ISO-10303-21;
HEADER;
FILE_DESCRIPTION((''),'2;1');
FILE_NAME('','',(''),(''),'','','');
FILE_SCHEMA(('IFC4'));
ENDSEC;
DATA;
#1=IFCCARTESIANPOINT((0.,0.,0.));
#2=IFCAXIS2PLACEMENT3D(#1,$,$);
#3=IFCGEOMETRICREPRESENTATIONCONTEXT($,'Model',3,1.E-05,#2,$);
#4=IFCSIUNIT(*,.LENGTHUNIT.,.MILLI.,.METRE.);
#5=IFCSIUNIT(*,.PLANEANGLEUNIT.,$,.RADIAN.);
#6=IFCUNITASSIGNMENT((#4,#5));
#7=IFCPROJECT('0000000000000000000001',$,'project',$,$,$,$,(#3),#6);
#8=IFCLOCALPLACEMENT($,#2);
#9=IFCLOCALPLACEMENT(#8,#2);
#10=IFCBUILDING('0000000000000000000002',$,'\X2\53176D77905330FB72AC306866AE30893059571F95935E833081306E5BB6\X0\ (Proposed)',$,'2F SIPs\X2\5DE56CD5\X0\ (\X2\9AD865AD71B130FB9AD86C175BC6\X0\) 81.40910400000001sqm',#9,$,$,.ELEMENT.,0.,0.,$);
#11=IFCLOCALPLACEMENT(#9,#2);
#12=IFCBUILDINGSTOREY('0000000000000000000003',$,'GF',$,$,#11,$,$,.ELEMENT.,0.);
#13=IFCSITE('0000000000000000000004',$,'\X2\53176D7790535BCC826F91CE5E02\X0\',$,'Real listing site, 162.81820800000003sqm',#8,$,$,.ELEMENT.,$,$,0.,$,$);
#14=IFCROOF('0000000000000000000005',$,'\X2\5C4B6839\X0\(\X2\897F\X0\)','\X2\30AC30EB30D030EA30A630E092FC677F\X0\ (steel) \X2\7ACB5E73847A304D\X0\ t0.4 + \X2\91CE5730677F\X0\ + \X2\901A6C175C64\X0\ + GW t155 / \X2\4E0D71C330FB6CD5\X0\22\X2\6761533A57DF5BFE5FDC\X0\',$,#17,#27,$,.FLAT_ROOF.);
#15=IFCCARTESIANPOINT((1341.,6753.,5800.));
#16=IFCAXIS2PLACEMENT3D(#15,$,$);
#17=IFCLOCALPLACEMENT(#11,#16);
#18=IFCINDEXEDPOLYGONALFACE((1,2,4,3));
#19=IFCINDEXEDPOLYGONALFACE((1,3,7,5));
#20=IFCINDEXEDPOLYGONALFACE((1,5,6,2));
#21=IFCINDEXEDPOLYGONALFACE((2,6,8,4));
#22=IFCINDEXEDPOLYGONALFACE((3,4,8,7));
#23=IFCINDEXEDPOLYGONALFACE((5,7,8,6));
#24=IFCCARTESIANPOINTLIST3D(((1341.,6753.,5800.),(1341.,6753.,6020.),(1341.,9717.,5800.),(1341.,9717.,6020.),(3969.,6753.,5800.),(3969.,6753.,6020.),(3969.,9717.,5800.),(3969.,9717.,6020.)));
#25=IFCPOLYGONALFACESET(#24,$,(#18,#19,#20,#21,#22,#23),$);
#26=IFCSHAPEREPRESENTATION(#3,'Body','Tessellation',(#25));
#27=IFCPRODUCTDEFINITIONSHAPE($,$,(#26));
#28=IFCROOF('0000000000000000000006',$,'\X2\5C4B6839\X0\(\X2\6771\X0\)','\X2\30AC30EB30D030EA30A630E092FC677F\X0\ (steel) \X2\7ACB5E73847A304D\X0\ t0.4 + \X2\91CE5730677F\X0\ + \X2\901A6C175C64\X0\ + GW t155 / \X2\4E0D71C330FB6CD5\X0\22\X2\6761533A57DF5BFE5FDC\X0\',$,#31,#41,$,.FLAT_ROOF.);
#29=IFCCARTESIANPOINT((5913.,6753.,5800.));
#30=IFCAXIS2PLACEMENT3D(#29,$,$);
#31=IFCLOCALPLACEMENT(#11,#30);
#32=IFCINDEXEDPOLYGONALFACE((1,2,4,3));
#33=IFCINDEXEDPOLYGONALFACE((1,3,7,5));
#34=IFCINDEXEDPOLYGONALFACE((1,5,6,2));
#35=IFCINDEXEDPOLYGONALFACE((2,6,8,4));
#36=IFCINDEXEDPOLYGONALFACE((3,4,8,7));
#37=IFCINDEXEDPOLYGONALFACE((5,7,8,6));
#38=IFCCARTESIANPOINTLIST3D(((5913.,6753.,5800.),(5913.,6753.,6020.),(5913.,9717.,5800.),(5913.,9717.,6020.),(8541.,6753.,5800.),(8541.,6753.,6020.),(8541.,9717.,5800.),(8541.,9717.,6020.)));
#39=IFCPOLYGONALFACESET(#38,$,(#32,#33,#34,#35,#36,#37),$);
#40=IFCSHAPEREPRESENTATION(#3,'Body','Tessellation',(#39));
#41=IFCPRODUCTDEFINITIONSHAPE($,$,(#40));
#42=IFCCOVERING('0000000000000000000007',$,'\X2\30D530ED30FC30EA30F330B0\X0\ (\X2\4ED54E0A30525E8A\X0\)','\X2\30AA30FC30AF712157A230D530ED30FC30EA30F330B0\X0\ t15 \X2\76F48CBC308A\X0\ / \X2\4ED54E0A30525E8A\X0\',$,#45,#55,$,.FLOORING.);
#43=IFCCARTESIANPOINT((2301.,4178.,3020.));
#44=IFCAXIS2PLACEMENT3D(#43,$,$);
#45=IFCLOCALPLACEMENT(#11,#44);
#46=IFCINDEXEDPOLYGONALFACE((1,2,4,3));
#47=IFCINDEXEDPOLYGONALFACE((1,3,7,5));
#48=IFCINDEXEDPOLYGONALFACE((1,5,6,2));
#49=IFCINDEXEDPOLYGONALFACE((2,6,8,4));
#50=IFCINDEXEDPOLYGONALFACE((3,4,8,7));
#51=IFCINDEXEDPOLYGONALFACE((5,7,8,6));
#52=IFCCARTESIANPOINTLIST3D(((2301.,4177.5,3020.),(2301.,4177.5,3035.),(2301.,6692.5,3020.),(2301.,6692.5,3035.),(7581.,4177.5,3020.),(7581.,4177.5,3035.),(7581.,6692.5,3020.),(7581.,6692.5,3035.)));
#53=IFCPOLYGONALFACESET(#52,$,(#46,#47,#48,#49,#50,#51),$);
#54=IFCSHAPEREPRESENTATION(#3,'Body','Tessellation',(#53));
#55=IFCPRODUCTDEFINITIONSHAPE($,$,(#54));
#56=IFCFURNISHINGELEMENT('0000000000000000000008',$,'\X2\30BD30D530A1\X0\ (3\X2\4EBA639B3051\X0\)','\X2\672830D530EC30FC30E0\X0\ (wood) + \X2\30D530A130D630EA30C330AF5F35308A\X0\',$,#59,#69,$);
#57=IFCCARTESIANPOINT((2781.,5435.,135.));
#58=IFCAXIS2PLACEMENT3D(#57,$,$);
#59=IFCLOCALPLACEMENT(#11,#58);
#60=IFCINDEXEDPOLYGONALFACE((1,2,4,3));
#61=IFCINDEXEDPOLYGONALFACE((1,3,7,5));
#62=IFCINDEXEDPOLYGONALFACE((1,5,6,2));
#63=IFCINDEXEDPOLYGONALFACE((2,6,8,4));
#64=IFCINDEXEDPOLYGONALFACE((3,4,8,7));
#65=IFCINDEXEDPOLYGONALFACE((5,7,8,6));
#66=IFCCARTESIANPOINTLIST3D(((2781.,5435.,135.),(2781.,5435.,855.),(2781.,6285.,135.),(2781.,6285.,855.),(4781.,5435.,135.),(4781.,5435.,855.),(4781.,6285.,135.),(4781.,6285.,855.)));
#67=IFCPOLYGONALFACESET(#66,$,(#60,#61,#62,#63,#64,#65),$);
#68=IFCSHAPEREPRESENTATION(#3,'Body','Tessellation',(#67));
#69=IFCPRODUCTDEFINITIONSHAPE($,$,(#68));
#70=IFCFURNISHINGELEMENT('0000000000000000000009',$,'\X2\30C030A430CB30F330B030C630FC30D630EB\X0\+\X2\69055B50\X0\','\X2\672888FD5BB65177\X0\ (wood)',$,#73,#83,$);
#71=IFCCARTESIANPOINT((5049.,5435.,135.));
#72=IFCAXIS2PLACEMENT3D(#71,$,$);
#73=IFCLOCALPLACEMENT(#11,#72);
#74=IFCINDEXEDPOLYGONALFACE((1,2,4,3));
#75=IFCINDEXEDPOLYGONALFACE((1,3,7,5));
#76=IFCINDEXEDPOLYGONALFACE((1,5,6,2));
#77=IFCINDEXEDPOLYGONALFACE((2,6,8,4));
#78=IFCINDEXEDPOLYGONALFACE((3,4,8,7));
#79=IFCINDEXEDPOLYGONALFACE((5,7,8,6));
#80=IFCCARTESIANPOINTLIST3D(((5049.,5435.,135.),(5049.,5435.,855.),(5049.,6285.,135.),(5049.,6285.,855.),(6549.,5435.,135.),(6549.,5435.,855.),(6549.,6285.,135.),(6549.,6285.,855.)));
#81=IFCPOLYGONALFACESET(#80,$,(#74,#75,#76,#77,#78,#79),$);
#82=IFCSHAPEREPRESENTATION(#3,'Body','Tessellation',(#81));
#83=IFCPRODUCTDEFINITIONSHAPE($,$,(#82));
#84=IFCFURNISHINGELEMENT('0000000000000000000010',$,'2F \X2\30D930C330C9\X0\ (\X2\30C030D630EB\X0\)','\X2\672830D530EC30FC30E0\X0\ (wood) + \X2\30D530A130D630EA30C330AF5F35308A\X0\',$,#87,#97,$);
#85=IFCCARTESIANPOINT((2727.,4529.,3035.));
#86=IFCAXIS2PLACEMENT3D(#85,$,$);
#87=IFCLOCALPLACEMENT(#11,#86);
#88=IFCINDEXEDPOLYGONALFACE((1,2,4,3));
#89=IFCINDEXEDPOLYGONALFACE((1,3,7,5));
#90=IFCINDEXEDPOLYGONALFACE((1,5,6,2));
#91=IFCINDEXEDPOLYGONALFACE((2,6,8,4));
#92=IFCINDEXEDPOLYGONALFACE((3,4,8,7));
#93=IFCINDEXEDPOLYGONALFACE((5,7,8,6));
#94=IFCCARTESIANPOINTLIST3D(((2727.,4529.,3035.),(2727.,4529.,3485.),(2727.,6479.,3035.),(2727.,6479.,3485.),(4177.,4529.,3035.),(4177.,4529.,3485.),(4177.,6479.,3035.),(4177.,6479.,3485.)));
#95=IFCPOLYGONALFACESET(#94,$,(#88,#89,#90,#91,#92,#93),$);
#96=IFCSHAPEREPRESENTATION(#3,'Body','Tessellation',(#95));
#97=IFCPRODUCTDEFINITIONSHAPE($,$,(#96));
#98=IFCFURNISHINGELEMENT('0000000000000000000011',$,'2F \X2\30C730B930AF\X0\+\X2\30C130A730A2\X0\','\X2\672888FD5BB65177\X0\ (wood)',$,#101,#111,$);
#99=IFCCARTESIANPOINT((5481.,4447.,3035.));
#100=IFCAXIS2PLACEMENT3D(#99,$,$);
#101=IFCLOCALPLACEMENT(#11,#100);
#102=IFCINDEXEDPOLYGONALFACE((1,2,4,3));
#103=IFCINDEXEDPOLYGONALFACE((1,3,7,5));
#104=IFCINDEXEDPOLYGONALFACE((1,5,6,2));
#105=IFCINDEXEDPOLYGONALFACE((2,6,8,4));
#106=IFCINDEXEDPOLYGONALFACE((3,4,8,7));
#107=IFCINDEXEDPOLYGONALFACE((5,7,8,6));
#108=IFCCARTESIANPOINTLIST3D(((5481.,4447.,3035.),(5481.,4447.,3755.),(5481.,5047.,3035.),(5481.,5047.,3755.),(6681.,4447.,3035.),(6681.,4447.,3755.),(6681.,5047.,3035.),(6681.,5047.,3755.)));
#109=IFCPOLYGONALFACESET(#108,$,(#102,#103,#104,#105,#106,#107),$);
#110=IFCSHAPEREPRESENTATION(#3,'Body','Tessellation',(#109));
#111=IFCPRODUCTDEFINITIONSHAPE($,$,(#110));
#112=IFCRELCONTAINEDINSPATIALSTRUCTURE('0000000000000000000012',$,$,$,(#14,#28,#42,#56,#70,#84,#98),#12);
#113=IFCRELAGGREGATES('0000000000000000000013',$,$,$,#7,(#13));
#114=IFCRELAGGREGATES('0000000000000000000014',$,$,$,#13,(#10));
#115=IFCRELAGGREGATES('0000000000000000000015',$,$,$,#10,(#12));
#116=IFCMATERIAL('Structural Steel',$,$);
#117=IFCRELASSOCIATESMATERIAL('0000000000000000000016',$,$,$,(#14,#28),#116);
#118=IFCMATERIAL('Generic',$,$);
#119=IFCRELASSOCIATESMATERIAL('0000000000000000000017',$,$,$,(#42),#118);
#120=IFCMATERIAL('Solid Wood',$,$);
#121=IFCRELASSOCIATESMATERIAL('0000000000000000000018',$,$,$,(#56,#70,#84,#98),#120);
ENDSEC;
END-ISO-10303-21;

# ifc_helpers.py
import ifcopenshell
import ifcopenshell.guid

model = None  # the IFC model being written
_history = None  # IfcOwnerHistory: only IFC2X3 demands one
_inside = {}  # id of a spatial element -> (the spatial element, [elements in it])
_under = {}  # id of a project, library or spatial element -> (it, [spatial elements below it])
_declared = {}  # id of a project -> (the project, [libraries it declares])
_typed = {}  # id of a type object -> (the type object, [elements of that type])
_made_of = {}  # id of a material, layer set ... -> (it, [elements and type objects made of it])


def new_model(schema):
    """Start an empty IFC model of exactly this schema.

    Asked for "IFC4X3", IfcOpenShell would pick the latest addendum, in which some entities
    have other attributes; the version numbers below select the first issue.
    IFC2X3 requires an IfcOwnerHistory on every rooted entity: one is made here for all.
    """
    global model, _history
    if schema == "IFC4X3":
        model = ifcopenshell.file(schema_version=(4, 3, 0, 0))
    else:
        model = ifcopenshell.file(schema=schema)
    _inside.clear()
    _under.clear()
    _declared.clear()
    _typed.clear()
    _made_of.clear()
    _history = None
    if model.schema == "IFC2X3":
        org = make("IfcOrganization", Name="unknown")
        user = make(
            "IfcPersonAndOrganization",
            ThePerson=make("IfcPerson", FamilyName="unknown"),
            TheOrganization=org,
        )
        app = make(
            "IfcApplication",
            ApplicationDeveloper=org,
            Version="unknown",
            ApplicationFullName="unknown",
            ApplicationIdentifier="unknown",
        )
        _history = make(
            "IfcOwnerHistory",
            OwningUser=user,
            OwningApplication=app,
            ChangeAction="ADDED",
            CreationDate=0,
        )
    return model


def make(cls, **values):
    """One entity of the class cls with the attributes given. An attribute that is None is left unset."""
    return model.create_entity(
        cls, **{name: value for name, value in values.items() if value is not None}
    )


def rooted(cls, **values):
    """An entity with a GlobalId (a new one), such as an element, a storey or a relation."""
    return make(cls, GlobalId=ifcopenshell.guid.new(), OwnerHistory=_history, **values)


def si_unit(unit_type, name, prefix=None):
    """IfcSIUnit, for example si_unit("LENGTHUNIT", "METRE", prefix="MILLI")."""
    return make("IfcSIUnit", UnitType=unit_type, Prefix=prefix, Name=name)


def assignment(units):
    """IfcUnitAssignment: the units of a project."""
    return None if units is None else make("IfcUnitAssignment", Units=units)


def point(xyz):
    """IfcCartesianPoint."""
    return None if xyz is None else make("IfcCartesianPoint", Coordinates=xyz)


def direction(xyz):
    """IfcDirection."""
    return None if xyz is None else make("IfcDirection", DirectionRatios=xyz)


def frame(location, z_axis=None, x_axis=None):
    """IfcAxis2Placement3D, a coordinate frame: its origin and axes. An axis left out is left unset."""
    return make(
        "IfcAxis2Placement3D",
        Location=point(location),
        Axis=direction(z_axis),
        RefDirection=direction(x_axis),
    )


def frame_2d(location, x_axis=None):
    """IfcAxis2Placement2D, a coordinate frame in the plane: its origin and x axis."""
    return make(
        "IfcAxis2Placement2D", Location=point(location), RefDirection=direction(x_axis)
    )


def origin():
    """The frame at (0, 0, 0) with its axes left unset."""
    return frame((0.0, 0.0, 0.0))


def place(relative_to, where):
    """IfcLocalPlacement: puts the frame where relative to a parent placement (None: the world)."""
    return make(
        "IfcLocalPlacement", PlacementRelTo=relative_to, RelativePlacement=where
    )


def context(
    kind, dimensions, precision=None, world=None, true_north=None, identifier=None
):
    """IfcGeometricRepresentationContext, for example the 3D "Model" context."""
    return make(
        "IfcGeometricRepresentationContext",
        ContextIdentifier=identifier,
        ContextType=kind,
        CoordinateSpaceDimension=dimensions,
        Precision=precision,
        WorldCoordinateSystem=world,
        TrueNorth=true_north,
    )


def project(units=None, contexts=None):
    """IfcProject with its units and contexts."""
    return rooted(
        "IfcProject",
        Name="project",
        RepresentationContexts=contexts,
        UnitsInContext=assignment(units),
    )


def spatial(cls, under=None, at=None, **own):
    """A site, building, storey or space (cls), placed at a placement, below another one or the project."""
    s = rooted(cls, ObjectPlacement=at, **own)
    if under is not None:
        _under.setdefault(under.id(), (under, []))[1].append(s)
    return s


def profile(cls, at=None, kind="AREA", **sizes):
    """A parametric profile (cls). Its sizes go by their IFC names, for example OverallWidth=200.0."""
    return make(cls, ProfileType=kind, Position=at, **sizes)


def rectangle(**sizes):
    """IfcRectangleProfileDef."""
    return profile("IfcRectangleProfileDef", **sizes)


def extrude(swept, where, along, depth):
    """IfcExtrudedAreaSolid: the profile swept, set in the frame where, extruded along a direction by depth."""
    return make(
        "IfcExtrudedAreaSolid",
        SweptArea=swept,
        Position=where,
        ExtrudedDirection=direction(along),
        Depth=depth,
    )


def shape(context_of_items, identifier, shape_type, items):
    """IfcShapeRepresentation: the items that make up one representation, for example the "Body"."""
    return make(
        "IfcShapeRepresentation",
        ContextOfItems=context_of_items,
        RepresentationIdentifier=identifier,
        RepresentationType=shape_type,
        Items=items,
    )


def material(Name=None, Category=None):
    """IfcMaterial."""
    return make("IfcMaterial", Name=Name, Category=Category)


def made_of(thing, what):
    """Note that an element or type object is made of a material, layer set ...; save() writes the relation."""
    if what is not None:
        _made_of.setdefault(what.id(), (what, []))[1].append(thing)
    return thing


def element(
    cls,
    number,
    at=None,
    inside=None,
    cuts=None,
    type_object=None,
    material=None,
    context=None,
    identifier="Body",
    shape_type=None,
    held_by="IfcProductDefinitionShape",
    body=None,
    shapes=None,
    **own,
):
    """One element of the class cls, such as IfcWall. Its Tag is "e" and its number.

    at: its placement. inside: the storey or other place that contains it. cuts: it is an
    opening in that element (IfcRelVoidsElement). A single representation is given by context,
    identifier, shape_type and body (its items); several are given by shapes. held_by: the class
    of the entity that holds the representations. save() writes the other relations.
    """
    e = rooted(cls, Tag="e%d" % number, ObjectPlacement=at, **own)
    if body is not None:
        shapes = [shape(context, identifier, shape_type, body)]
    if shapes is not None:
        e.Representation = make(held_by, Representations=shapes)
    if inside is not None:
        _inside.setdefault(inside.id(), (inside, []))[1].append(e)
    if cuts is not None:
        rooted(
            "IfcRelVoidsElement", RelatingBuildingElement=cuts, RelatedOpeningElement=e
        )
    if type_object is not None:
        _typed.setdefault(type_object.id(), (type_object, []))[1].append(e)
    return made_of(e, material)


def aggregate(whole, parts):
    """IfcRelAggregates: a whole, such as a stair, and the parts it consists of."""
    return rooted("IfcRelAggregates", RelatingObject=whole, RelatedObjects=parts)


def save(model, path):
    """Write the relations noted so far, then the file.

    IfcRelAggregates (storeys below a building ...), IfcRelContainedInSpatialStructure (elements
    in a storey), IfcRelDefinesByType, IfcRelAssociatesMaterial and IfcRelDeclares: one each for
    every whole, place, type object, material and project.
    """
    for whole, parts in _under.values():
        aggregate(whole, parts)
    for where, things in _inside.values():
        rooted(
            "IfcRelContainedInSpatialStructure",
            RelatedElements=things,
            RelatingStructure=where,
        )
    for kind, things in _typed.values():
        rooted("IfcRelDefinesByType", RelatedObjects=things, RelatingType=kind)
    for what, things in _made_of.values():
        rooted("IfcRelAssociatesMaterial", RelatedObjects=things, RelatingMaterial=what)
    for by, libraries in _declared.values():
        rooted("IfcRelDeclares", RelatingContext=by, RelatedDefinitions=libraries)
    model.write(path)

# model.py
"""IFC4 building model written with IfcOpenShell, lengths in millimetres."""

from ifc_helpers import new_model, si_unit, frame, frame_2d, origin, place, context, project, spatial, rectangle, extrude, material, element, save


model = new_model("IFC4")

# Units and contexts
model_context = context("Model", 3, precision=1e-05, world=origin())
ifc_project = project(units=[si_unit("LENGTHUNIT", "METRE", prefix="MILLI"), si_unit("PLANEANGLEUNIT", "RADIAN")], contexts=[model_context])

# Site, building, storey
site_placement = place(None, origin())
site = spatial("IfcSite", under=ifc_project, at=site_placement, Name="北海道富良野市", ObjectType="Real listing site, 162.81820800000003sqm", CompositionType="ELEMENT", RefElevation=0.0)
building_placement = place(site_placement, origin())
building = spatial("IfcBuilding", under=site, at=building_placement, Name="北海道・犬と暮らす土間広めの家 (Proposed)", ObjectType="2F SIPs工法 (高断熱・高気密) 81.40910400000001sqm", CompositionType="ELEMENT", ElevationOfRefHeight=0.0, ElevationOfTerrain=0.0)
storey_placement = place(building_placement, origin())
storey = spatial("IfcBuildingStorey", under=building, at=storey_placement, Name="GF", CompositionType="ELEMENT", Elevation=0.0)

# Shared definitions
ifc_material_1 = material(Name="Solid Wood")

# Roofs
ifc_material_2 = material(Name="Structural Steel")
roof_1_placement = place(storey_placement, frame((1341.0, 6753.0, 5800.0)))
element("IfcRoof", 1, at=roof_1_placement, inside=storey, material=ifc_material_2, Name="屋根(西)", Description="ガルバリウム鋼板 (steel) 立平葺き t0.4 + 野地板 + 通気層 + GW t155 / 不燃・法22条区域対応", PredefinedType="FLAT_ROOF", context=model_context, shape_type="SweptSolid", body=[
    extrude(rectangle(XDim=2628.0, YDim=2964.0, at=frame_2d((1314.0, 1482.0))), frame((1341.0, 6753.0, 5800.0)), (0.0, 0.0, 1.0), 220.0),
])
roof_2_placement = place(storey_placement, frame((5913.0, 6753.0, 5800.0)))
element("IfcRoof", 2, at=roof_2_placement, inside=storey, material=ifc_material_2, Name="屋根(東)", Description="ガルバリウム鋼板 (steel) 立平葺き t0.4 + 野地板 + 通気層 + GW t155 / 不燃・法22条区域対応", PredefinedType="FLAT_ROOF", context=model_context, shape_type="SweptSolid", body=[
    extrude(rectangle(XDim=2628.0, YDim=2964.0, at=frame_2d((1314.0, 1482.0))), frame((5913.0, 6753.0, 5800.0)), (0.0, 0.0, 1.0), 220.0),
])

# Covering
ifc_material_3 = material(Name="Generic")
covering_placement = place(storey_placement, frame((2301.0, 4178.0, 3020.0)))
element("IfcCovering", 3, at=covering_placement, inside=storey, material=ifc_material_3, Name="フローリング (仕上げ床)", Description="オーク無垢フローリング t15 直貼り / 仕上げ床", PredefinedType="FLOORING", context=model_context, shape_type="SweptSolid", body=[
    extrude(rectangle(XDim=5280.0, YDim=2515.0, at=frame_2d((2640.0, 1257.0))), frame((2301.0, 4178.0, 3020.0)), (0.0, 0.0, 1.0), 15.0),
])

# Furnishing elements
furnishing_1_placement = place(storey_placement, frame((2781.0, 5435.0, 135.0)))
element("IfcFurnishingElement", 4, at=furnishing_1_placement, inside=storey, material=ifc_material_1, Name="ソファ (3人掛け)", Description="木フレーム (wood) + ファブリック張り", context=model_context, shape_type="SweptSolid", body=[
    extrude(rectangle(XDim=2000.0, YDim=850.0, at=frame_2d((1000.0, 425.0))), frame((2781.0, 5435.0, 135.0)), (0.0, 0.0, 1.0), 720.0),
])
furnishing_2_placement = place(storey_placement, frame((5049.0, 5435.0, 135.0)))
element("IfcFurnishingElement", 5, at=furnishing_2_placement, inside=storey, material=ifc_material_1, Name="ダイニングテーブル+椅子", Description="木製家具 (wood)", context=model_context, shape_type="SweptSolid", body=[
    extrude(rectangle(XDim=1500.0, YDim=850.0, at=frame_2d((750.0, 425.0))), frame((5049.0, 5435.0, 135.0)), (0.0, 0.0, 1.0), 720.0),
])
furnishing_3_placement = place(storey_placement, frame((2727.0, 4529.0, 3035.0)))
element("IfcFurnishingElement", 6, at=furnishing_3_placement, inside=storey, material=ifc_material_1, Name="2F ベッド (ダブル)", Description="木フレーム (wood) + ファブリック張り", context=model_context, shape_type="SweptSolid", body=[
    extrude(rectangle(XDim=1450.0, YDim=1950.0, at=frame_2d((725.0, 975.0))), frame((2727.0, 4529.0, 3035.0)), (0.0, 0.0, 1.0), 450.0),
])
furnishing_4_placement = place(storey_placement, frame((5481.0, 4447.0, 3035.0)))
element("IfcFurnishingElement", 7, at=furnishing_4_placement, inside=storey, material=ifc_material_1, Name="2F デスク+チェア", Description="木製家具 (wood)", context=model_context, shape_type="SweptSolid", body=[
    extrude(rectangle(XDim=1200.0, YDim=600.0, at=frame_2d((600.0, 300.0))), frame((5481.0, 4447.0, 3035.0)), (0.0, 0.0, 1.0), 720.0),
])

save(model, "model.ifc")
